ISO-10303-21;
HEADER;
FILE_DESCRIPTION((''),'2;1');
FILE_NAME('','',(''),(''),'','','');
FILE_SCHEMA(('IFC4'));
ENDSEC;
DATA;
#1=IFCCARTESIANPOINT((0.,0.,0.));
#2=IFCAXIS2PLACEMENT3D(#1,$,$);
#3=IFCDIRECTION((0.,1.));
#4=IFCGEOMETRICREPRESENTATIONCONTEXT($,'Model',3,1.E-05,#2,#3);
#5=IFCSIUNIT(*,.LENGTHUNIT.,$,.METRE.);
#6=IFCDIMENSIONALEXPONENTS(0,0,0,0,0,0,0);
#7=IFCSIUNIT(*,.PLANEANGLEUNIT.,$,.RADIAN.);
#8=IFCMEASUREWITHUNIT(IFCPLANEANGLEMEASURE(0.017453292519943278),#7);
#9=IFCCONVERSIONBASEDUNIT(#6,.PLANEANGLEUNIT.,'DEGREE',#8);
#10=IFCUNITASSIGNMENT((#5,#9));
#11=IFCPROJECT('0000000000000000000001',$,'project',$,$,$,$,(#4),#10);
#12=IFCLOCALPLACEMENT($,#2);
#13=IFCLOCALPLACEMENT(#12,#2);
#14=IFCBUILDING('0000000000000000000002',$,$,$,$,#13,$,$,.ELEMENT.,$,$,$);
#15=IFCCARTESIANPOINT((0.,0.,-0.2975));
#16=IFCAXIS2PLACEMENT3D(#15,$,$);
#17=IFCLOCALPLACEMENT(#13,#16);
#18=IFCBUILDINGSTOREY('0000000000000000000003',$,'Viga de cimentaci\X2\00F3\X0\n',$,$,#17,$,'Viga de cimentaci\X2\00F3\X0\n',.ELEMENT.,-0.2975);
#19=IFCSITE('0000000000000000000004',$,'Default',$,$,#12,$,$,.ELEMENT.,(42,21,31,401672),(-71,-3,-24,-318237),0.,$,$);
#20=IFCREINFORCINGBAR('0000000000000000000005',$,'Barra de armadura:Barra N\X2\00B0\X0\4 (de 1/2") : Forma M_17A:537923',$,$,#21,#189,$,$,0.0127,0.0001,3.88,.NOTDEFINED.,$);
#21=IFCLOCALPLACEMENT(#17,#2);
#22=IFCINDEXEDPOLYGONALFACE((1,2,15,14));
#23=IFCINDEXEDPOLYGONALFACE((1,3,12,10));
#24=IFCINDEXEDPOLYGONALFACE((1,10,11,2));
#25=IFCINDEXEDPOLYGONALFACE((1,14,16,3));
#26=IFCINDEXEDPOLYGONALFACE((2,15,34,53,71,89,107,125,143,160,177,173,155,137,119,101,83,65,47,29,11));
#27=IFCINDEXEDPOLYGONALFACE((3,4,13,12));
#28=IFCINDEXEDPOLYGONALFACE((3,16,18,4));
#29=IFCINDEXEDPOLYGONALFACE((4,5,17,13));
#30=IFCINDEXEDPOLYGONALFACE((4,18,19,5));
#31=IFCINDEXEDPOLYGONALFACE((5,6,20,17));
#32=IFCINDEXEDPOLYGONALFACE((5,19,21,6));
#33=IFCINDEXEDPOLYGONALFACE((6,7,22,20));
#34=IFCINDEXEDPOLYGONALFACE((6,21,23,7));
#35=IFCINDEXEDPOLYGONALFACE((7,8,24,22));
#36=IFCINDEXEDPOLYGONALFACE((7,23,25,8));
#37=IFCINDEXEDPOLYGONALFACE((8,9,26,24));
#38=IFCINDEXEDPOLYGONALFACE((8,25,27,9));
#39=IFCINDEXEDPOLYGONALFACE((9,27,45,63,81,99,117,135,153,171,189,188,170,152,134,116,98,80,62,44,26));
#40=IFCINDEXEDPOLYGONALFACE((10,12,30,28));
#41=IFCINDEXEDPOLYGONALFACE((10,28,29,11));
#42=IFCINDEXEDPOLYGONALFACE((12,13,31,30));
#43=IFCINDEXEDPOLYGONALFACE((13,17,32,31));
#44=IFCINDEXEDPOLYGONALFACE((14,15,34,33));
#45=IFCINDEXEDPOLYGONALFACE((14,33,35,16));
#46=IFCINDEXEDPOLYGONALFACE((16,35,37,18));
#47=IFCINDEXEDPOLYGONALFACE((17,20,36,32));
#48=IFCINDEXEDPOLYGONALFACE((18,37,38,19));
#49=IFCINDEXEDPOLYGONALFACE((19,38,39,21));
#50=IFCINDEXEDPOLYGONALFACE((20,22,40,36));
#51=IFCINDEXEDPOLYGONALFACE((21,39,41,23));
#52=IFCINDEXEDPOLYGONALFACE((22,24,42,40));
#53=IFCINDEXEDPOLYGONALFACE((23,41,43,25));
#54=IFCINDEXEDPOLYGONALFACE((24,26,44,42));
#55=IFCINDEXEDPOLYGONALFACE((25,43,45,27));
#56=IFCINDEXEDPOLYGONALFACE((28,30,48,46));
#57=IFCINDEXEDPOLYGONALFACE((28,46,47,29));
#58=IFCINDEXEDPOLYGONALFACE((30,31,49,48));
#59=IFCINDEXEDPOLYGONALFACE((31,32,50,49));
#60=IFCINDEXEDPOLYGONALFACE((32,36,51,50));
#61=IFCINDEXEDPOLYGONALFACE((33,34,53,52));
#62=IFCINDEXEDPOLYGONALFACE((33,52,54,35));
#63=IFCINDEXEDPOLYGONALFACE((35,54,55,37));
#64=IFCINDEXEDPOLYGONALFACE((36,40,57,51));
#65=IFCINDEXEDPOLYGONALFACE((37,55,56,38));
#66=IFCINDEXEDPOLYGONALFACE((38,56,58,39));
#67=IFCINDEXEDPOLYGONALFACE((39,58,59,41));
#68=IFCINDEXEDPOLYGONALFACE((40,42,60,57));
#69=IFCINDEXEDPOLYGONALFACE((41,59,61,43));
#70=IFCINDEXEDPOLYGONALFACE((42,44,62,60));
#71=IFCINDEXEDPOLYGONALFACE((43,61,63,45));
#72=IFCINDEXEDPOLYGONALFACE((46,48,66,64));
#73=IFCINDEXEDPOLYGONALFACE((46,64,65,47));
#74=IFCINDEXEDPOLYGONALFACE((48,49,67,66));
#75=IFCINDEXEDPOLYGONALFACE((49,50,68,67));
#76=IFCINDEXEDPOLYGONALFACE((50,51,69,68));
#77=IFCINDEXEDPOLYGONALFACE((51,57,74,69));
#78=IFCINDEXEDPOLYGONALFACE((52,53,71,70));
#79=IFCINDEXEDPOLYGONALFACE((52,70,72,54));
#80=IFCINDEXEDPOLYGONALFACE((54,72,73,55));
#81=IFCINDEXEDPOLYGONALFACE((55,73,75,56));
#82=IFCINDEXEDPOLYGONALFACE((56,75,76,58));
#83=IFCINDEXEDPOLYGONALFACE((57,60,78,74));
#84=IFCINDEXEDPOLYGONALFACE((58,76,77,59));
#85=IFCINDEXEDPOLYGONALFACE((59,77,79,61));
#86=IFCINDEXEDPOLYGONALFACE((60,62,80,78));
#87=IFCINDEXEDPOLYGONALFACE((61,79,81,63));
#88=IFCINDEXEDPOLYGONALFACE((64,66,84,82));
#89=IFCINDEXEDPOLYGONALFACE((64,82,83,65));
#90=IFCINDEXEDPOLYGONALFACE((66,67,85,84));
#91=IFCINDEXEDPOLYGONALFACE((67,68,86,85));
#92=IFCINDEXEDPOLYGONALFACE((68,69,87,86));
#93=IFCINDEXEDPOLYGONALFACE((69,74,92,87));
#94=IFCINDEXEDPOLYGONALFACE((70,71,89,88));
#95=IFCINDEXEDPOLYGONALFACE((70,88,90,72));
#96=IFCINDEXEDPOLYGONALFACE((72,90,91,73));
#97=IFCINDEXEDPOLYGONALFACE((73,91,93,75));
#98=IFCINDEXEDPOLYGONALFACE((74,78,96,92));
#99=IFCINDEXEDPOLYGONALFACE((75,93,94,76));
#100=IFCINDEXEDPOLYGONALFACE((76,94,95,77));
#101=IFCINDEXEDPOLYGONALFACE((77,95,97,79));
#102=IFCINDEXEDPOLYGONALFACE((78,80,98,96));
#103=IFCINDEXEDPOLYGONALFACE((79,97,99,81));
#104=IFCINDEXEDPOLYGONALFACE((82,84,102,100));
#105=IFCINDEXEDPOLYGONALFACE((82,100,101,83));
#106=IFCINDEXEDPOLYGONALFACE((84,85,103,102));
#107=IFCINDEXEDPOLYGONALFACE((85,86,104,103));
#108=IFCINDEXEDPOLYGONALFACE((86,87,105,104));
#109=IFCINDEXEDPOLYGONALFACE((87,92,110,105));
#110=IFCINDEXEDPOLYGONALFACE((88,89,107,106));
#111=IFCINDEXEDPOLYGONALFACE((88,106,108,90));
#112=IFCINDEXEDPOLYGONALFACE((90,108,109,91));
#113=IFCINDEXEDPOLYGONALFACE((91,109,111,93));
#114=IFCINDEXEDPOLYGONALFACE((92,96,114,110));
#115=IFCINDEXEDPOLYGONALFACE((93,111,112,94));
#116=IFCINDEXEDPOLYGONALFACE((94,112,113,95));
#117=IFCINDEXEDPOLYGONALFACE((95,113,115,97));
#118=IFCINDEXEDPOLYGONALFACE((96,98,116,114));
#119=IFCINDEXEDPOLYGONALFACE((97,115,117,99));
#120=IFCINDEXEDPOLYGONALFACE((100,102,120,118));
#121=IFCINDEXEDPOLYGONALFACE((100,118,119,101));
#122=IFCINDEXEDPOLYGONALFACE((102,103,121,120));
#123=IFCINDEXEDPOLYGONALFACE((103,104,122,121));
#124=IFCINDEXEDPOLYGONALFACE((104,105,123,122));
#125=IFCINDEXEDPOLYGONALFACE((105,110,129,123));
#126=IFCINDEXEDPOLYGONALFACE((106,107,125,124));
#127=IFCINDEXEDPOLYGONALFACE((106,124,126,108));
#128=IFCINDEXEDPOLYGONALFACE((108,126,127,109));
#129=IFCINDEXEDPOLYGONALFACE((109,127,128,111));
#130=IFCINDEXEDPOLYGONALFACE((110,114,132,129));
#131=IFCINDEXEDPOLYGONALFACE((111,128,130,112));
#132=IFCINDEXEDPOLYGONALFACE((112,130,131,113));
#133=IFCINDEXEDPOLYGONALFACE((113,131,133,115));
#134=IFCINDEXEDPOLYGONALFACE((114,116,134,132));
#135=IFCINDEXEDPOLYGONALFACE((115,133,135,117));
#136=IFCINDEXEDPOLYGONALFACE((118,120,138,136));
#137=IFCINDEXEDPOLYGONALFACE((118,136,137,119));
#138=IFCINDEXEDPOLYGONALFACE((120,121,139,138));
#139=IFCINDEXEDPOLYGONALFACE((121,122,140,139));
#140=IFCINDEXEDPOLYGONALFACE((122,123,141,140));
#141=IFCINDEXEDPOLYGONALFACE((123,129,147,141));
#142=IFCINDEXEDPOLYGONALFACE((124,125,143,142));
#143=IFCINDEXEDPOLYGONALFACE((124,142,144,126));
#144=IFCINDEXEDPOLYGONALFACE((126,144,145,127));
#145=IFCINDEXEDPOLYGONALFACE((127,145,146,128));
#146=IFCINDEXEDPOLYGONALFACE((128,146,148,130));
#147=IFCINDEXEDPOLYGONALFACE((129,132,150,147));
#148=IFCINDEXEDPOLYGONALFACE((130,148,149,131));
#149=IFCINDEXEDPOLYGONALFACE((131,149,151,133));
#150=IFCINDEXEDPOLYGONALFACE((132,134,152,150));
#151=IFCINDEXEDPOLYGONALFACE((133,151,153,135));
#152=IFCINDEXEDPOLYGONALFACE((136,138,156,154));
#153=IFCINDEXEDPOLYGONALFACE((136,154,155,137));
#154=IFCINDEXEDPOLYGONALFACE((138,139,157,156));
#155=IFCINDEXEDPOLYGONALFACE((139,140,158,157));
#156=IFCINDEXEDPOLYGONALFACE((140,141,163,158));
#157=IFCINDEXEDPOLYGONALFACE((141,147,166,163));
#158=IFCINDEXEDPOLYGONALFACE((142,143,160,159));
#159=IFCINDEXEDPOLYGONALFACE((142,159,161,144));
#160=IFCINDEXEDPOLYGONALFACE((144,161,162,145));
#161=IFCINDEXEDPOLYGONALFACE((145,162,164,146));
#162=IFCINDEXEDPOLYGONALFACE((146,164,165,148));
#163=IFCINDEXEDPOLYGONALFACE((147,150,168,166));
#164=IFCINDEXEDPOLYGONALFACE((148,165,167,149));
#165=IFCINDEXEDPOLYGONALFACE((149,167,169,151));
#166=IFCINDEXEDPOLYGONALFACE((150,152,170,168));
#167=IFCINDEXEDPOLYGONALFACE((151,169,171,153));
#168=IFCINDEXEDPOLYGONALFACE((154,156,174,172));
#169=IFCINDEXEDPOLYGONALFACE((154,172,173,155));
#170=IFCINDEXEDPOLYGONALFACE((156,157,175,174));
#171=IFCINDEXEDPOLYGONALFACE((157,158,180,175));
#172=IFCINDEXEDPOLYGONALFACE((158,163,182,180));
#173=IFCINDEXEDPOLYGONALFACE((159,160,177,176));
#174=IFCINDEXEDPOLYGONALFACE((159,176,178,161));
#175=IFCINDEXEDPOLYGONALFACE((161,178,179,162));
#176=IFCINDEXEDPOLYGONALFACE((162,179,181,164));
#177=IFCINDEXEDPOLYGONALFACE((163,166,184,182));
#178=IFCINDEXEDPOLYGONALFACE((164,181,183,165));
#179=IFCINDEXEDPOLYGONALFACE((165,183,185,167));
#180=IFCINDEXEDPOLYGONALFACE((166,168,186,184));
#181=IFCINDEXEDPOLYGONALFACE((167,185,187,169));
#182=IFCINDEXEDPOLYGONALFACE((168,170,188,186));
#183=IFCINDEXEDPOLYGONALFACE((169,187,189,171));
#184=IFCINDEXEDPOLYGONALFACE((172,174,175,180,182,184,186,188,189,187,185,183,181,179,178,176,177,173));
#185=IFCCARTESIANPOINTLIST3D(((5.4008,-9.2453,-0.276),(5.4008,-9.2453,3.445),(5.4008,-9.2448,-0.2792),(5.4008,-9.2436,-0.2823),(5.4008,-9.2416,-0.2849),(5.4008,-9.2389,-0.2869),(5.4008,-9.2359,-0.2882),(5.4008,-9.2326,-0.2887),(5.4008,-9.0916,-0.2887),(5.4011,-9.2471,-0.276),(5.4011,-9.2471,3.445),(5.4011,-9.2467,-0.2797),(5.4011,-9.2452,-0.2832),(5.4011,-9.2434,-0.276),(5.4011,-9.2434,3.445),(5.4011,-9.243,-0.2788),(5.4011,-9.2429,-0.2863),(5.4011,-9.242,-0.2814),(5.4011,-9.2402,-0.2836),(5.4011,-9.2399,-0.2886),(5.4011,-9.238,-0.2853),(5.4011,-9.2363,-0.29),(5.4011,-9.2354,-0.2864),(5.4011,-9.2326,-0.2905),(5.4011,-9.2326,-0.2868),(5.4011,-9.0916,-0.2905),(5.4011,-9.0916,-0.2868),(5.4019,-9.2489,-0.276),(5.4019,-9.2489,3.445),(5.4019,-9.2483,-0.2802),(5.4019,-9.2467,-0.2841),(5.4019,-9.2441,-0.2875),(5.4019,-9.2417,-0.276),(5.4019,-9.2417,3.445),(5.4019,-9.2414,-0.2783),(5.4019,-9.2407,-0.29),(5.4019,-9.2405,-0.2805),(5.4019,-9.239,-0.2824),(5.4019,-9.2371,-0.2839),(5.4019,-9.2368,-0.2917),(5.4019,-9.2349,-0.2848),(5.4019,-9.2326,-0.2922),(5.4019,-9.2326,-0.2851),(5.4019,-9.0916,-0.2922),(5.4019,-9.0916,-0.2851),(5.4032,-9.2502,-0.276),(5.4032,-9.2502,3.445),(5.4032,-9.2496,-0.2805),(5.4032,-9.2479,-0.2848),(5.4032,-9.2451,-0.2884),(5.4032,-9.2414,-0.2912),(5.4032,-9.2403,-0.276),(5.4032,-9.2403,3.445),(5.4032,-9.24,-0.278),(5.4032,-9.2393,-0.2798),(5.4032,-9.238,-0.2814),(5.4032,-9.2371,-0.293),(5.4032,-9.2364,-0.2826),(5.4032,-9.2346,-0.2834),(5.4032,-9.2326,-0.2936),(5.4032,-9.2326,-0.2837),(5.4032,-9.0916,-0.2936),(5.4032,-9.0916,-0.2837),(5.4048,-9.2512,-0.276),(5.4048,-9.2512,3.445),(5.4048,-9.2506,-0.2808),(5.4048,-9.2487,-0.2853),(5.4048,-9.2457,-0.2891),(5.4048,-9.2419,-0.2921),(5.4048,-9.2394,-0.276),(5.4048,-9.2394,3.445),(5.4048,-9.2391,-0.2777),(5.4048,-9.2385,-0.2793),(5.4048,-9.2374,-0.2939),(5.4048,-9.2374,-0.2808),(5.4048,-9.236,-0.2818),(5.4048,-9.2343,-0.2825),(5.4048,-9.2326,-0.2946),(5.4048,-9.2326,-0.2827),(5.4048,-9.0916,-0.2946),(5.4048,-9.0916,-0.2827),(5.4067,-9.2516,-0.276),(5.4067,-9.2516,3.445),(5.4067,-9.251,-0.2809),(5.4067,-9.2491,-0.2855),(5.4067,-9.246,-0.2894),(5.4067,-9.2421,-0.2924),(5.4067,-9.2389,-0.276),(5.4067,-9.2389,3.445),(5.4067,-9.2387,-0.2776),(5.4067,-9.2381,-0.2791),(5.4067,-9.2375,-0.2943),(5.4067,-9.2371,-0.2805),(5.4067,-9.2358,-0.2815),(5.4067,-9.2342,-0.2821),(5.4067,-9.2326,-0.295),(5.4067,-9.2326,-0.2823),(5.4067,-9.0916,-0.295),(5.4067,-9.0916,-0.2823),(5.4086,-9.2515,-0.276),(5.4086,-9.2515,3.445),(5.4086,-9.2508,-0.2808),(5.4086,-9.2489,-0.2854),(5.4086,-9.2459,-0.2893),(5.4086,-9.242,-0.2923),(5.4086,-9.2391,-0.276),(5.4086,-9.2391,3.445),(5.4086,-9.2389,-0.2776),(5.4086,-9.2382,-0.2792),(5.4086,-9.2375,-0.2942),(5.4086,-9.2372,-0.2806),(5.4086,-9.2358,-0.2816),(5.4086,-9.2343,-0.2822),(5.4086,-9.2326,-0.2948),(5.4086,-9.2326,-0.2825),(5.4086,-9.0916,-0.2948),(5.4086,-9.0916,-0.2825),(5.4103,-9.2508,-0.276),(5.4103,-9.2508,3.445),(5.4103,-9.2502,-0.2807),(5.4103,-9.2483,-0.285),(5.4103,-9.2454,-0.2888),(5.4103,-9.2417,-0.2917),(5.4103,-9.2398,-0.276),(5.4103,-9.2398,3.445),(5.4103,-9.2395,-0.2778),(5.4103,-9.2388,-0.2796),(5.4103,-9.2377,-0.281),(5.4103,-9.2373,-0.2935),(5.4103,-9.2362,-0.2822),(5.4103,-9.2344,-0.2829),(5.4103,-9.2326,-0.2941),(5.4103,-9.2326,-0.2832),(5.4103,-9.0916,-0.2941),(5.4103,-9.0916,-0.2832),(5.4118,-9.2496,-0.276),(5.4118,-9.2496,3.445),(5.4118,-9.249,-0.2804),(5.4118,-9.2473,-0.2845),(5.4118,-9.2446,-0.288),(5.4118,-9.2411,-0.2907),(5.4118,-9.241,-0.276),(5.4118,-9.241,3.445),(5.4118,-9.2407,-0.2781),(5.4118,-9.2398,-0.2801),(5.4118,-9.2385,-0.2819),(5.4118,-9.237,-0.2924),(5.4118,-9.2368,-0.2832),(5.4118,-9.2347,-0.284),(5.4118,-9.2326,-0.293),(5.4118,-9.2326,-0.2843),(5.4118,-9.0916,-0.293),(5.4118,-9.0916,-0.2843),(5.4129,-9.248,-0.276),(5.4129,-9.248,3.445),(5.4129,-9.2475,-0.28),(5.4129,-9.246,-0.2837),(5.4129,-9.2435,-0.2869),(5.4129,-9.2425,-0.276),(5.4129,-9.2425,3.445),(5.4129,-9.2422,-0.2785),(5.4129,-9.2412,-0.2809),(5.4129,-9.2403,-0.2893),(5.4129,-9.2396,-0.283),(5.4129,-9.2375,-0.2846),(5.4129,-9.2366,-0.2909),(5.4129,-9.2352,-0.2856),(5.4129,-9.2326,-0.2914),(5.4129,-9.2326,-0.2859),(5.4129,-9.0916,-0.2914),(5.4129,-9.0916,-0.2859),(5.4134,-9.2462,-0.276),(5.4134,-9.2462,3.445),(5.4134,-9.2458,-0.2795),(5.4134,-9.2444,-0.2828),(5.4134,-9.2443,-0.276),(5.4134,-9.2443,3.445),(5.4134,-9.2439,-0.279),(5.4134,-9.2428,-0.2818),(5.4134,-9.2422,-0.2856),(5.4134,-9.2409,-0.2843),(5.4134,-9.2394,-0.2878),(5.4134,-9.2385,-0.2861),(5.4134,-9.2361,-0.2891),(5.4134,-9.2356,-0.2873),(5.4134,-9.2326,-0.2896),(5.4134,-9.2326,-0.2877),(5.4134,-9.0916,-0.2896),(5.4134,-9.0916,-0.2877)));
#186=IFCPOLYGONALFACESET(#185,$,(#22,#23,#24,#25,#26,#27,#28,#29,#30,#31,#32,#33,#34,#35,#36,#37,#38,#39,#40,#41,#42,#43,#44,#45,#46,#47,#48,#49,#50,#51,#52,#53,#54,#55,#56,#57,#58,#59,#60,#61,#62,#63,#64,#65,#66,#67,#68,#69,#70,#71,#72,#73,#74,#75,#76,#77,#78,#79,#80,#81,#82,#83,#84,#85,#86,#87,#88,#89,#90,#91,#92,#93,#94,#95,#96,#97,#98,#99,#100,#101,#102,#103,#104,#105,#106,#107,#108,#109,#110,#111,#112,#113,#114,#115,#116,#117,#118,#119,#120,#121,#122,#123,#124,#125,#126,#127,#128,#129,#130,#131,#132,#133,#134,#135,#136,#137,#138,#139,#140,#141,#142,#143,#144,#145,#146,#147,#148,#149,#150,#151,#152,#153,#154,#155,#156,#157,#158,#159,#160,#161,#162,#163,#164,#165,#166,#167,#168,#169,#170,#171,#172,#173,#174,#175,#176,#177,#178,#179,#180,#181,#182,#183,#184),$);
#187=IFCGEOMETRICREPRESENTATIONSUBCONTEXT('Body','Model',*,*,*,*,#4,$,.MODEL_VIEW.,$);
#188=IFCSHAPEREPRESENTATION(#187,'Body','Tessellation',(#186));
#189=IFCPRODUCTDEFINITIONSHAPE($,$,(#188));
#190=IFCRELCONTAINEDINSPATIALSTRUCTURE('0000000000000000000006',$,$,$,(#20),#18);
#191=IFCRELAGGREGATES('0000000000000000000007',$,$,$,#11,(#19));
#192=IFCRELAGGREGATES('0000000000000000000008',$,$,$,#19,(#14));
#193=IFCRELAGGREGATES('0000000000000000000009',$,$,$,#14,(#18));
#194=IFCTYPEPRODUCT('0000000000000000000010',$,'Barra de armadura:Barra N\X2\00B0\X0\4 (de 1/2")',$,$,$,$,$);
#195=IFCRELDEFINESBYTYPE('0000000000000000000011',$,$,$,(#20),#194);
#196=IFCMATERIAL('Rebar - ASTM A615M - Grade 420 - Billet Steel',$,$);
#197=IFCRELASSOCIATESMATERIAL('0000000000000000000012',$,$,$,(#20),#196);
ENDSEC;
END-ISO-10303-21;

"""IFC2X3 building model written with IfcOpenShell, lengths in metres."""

from ifc_helpers import new_model, entity, si_unit, converted_unit, direction, frame, origin, place, context, subcontext, project, spatial, material, type_object, element, save


model = new_model("IFC2X3")

# Units and contexts
model_context = context("Model", 3, precision=1e-05, world=origin(), true_north=direction((0.0, 1.0)))
body_context = subcontext(model_context, "Body", "Model", "MODEL_VIEW")
ifc_project = project(units=[si_unit("LENGTHUNIT", "METRE"), converted_unit("PLANEANGLEUNIT", "DEGREE", entity("IfcPlaneAngleMeasure", 0.017453292519943278), si_unit("PLANEANGLEUNIT", "RADIAN"), dimensions=[0, 0, 0, 0, 0, 0, 0])], contexts=[model_context])

# Site, building, storey
site_placement = place(None, origin())
site = spatial("IfcSite", under=ifc_project, at=site_placement, Name="Default", CompositionType="ELEMENT", RefLatitude=(42, 21, 31, 401672), RefLongitude=(-71, -3, -24, -318237), RefElevation=0.0)
building_placement = place(site_placement, origin())
building = spatial("IfcBuilding", under=site, at=building_placement, CompositionType="ELEMENT")
storey_placement = place(building_placement, frame((0.0, 0.0, -0.2975)))
storey = spatial("IfcBuildingStorey", under=building, at=storey_placement, Name="Viga de cimentación", LongName="Viga de cimentación", CompositionType="ELEMENT", Elevation=-0.2975)

# Reinforcing bar
ifc_material_1 = material(Name="Rebar - ASTM A615M - Grade 420 - Billet Steel")
type_product_1 = type_object("IfcTypeProduct", Name="Barra de armadura:Barra N°4 (de 1/2\")")
reinforcing_bar_1_placement = place(storey_placement, origin())
element("IfcReinforcingBar", 1, at=reinforcing_bar_1_placement, inside=storey, type_object=type_product_1, material=ifc_material_1, Name="Barra de armadura:Barra N°4 (de 1/2\") : Forma M_17A:537923", BarLength=3.88, BarRole="NOTDEFINED", CrossSectionArea=0.0001, NominalDiameter=0.0127, context=body_context, shape_type="AdvancedSweptSolid", body=[
    entity("IfcSweptDiskSolid", entity("IfcCompositeCurve", [entity("IfcCompositeCurveSegment", "CONTINUOUS", True, entity("IfcPolyline", [entity("IfcCartesianPoint", [5.4071, -9.2453, 3.445]), entity("IfcCartesianPoint", [5.4071, -9.2453, -0.276])])), entity("IfcCompositeCurveSegment", "CONTINUOUS", True, entity("IfcTrimmedCurve", entity("IfcCircle", entity("IfcAxis2Placement3D", entity("IfcCartesianPoint", [5.4071, -9.2326, -0.276]), entity("IfcDirection", [1.0, 0.0, 0.0]), entity("IfcDirection", [0.0, 0.0, -1.0])), 0.0127), [entity("IfcParameterValue", 270.0)], [entity("IfcParameterValue", 360.0)], True, "PARAMETER")), entity("IfcCompositeCurveSegment", "CONTINUOUS", True, entity("IfcPolyline", [entity("IfcCartesianPoint", [5.4071, -9.2326, -0.2887]), entity("IfcCartesianPoint", [5.4071, -9.0916, -0.2887])]))], False), 0.0063, None, 0.0, 92.0),
])

save(model, "model.ifc")
